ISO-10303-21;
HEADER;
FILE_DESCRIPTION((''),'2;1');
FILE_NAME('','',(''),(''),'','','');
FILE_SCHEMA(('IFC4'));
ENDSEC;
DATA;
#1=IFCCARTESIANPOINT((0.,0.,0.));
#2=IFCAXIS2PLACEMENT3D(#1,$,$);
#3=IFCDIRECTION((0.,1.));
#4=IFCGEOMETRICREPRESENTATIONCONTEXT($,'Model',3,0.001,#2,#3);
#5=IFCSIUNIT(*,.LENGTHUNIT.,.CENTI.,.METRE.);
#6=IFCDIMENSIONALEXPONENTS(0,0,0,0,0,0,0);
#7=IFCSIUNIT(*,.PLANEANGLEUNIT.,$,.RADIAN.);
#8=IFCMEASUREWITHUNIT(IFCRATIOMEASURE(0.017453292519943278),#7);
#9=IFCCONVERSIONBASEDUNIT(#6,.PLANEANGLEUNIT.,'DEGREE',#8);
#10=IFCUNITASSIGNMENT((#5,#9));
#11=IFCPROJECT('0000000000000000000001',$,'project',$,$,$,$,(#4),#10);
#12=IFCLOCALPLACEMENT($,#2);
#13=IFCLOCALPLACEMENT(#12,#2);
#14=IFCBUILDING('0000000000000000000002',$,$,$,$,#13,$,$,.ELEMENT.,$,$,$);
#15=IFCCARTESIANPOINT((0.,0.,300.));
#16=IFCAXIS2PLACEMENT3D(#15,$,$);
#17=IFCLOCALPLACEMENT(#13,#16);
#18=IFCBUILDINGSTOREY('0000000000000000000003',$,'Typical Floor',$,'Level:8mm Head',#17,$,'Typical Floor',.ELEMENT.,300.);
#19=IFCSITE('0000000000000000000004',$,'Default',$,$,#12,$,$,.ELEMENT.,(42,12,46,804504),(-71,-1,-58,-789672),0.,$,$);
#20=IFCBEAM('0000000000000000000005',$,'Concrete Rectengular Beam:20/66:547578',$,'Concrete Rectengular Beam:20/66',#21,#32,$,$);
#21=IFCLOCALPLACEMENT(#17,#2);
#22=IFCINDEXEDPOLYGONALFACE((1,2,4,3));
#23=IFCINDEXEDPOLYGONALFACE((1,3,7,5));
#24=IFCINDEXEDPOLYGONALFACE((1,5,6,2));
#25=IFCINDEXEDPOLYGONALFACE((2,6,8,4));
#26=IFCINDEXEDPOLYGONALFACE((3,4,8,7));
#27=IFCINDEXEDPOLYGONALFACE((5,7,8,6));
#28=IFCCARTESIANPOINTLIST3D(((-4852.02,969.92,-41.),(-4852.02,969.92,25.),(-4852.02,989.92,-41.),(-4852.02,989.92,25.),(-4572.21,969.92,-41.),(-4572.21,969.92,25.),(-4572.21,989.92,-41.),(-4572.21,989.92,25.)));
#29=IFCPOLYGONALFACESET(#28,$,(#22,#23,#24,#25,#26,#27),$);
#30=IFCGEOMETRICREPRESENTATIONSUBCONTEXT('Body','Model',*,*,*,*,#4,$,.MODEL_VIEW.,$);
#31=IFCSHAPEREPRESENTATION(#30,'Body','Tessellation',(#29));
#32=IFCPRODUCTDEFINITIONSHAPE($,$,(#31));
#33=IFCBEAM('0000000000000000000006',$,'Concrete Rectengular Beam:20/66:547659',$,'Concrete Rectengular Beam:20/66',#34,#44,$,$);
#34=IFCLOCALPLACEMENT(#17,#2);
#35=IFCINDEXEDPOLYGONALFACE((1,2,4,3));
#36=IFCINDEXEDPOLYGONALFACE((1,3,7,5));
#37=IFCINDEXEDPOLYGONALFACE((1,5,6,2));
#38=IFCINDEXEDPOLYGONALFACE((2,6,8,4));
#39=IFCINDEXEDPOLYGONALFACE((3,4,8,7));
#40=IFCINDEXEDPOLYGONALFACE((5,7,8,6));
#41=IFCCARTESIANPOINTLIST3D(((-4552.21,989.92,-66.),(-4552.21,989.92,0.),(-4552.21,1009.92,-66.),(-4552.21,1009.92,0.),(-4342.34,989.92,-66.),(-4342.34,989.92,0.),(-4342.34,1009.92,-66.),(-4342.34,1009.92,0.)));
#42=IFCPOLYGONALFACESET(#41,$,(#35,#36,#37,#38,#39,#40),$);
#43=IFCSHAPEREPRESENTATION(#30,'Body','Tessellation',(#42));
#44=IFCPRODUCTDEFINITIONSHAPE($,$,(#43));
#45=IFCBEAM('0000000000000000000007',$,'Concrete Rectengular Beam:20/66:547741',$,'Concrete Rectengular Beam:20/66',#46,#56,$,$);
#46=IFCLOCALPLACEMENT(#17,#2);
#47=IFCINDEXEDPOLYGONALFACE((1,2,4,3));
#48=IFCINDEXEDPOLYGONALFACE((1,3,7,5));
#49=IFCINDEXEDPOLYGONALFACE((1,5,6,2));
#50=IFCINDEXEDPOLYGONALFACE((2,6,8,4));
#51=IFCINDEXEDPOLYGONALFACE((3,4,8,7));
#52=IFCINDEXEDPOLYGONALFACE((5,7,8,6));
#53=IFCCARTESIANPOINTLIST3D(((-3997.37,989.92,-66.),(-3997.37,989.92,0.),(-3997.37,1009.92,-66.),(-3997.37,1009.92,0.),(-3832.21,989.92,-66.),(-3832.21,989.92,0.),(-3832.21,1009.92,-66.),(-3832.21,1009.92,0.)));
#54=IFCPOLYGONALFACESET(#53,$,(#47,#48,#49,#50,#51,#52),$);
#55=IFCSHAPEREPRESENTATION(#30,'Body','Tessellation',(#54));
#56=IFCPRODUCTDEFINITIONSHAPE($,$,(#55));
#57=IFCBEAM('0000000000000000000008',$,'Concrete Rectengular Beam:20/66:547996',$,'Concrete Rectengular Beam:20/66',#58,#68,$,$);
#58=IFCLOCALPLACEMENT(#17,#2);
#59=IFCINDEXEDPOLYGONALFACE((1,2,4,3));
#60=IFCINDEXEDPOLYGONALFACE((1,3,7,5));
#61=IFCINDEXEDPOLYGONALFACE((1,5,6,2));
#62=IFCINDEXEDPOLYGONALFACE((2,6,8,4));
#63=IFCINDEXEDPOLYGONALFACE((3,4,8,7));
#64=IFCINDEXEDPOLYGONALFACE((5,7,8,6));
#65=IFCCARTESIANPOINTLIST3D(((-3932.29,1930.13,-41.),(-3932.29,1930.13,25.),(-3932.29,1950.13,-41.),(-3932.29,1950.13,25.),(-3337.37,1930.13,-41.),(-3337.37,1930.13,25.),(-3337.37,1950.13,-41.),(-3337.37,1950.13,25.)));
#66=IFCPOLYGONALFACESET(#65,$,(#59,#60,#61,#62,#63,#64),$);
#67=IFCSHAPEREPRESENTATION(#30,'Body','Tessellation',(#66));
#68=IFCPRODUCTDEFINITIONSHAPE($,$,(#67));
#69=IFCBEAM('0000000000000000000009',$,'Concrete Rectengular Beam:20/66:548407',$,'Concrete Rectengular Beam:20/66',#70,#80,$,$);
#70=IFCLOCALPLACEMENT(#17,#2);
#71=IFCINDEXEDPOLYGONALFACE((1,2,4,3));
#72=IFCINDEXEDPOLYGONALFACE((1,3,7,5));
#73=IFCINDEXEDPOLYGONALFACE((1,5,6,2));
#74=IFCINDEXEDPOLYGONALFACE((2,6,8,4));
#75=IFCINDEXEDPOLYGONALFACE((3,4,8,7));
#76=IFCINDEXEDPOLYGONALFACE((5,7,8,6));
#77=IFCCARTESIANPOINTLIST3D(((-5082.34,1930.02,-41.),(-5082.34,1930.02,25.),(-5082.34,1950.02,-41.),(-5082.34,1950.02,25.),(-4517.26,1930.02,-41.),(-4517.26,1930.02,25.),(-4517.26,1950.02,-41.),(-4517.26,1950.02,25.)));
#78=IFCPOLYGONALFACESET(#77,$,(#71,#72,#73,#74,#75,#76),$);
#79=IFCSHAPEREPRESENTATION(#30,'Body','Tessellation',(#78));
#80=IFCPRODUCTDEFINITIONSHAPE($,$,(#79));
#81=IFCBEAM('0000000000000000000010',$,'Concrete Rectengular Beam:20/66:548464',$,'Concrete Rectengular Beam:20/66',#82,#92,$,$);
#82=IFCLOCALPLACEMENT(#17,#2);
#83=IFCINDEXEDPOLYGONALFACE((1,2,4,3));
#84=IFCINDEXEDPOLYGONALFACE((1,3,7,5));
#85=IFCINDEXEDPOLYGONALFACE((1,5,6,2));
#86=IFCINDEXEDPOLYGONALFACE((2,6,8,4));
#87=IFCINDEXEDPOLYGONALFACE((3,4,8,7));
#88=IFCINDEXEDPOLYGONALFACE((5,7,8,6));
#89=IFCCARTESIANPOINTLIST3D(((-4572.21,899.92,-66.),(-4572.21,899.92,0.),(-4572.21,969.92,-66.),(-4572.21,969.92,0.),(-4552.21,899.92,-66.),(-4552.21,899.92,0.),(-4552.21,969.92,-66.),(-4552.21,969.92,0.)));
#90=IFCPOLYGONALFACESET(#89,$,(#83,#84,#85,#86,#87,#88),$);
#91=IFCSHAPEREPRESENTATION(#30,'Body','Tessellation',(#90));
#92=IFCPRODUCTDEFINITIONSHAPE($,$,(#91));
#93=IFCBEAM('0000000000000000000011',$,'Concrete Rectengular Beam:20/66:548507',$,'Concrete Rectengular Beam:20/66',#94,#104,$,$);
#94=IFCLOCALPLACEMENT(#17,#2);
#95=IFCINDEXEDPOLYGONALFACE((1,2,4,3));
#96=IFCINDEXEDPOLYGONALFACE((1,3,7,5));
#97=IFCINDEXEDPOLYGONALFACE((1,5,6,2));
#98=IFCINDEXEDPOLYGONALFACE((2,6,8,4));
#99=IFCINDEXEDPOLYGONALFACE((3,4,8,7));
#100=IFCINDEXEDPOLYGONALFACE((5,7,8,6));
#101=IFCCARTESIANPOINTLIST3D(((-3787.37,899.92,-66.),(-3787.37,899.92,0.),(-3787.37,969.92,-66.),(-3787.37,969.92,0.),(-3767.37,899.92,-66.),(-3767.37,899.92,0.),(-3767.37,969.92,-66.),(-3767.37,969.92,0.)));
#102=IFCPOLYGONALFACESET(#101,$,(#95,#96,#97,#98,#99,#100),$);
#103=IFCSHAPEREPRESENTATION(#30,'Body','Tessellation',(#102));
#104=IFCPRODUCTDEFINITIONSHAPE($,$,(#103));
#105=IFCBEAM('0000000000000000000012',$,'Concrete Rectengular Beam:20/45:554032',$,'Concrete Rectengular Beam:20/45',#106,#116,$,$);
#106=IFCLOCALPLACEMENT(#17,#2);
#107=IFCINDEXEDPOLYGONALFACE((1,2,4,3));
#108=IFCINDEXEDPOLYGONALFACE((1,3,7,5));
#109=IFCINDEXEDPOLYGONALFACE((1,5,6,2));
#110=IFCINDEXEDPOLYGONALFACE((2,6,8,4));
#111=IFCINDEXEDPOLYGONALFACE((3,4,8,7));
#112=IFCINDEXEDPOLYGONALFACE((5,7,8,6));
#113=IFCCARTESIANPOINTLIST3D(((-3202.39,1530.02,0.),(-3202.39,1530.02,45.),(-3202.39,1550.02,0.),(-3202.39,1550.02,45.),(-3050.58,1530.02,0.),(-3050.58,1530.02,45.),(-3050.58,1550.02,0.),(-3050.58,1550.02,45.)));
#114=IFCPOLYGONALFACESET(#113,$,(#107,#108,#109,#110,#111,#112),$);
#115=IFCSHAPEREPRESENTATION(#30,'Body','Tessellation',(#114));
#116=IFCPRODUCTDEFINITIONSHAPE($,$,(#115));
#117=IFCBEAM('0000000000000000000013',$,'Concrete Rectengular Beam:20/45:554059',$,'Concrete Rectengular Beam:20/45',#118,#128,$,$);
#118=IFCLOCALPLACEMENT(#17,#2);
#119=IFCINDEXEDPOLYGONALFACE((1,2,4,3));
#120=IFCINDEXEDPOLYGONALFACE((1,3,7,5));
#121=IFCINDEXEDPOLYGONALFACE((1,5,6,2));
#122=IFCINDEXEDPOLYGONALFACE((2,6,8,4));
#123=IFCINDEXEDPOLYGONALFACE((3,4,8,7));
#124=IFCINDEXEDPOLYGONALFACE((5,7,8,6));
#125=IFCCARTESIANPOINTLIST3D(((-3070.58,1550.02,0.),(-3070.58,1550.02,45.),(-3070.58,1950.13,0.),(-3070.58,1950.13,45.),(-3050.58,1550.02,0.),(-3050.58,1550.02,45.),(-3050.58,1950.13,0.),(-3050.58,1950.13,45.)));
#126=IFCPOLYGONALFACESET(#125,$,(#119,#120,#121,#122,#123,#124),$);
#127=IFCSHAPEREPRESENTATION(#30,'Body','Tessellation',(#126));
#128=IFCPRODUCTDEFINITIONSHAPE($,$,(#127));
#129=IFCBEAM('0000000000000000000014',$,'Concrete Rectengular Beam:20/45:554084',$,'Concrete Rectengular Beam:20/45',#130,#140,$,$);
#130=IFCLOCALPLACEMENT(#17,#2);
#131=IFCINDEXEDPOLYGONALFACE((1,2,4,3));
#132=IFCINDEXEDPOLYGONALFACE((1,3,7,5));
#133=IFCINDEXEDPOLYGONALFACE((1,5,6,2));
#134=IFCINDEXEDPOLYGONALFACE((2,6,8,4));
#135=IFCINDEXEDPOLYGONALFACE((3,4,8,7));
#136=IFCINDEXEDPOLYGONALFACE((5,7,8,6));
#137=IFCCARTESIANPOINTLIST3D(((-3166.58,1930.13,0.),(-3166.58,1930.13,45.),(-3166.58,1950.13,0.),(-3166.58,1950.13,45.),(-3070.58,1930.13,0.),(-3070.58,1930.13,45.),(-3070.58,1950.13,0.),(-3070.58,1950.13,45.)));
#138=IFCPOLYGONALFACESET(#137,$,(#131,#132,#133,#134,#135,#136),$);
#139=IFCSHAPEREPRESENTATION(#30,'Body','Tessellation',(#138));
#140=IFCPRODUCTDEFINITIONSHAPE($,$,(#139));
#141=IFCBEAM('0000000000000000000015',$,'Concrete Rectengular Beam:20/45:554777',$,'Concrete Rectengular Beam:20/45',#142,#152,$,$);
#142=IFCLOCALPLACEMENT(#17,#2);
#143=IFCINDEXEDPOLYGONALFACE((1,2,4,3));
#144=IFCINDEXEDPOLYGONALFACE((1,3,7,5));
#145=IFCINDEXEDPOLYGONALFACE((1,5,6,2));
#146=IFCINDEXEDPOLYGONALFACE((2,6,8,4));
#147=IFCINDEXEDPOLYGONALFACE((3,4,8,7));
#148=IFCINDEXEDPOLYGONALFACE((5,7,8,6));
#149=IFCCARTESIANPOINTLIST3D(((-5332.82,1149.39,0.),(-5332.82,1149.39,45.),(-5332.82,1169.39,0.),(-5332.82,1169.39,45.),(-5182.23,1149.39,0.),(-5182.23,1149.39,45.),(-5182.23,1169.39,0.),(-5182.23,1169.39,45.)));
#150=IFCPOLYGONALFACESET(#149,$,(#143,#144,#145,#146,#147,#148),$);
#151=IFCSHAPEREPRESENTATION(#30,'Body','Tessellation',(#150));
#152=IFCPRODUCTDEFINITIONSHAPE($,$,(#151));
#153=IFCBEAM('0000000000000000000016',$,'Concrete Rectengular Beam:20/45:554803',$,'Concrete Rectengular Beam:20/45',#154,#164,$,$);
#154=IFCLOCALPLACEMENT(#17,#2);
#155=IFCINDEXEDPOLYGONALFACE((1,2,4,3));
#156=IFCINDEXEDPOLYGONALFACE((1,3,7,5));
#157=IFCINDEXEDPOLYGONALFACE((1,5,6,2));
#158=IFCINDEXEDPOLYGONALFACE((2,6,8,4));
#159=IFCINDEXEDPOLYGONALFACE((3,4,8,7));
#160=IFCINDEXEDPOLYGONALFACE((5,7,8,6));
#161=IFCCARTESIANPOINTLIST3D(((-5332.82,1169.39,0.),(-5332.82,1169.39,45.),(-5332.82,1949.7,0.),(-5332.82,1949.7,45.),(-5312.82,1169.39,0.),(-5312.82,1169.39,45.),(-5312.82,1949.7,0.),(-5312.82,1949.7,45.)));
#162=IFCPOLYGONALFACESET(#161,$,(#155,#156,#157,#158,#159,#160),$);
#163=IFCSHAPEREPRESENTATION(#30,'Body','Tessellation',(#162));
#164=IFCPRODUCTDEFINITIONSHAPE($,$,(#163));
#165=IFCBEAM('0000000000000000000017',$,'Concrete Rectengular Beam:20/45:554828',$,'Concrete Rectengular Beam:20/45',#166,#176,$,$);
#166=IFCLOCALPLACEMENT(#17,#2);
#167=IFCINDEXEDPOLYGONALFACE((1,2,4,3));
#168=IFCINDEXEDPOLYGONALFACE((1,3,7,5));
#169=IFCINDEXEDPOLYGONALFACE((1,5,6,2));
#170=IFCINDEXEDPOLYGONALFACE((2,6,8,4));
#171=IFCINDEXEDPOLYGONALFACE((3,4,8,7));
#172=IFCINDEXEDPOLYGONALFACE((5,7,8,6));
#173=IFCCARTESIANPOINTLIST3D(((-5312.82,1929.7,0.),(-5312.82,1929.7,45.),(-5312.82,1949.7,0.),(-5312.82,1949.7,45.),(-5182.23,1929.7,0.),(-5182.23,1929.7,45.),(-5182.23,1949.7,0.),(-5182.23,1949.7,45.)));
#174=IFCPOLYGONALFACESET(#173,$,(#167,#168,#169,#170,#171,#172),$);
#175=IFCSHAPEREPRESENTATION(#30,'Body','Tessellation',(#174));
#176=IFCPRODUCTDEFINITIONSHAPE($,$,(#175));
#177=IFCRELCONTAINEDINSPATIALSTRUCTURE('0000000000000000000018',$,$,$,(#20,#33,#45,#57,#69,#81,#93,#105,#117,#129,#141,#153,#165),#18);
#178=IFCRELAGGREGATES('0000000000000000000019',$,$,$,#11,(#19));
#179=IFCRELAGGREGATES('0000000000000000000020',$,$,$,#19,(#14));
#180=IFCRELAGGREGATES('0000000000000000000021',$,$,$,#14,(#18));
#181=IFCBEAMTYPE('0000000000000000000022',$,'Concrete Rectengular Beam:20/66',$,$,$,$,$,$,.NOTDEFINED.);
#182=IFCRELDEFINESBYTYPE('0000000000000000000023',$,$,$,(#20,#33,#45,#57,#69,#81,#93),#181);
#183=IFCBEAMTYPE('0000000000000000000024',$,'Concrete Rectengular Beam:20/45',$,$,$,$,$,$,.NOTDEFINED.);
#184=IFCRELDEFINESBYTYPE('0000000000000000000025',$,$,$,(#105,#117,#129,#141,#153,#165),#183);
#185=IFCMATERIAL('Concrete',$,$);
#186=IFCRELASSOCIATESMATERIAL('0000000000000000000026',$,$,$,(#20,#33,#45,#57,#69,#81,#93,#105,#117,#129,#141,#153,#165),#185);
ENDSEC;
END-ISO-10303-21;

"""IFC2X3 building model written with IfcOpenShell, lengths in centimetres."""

from ifc_helpers import new_model, entity, si_unit, converted_unit, direction, frame, frame_2d, origin, place, context, subcontext, project, spatial, rectangle, extrude, material, type_object, element, save


model = new_model("IFC2X3")

# Units and contexts
model_context = context("Model", 3, precision=0.001, world=origin(), true_north=direction((0.0, 1.0)))
body_context = subcontext(model_context, "Body", "Model", "MODEL_VIEW")
ifc_project = project(units=[si_unit("LENGTHUNIT", "METRE", prefix="CENTI"), converted_unit("PLANEANGLEUNIT", "DEGREE", entity("IfcRatioMeasure", 0.017453292519943278), si_unit("PLANEANGLEUNIT", "RADIAN"), dimensions=[0, 0, 0, 0, 0, 0, 0])], contexts=[model_context])

# Site, building, storey
site_placement = place(None, origin())
site = spatial("IfcSite", under=ifc_project, at=site_placement, Name="Default", CompositionType="ELEMENT", RefLatitude=(42, 12, 46, 804504), RefLongitude=(-71, -1, -58, -789672), RefElevation=0.0)
building_placement = place(site_placement, origin())
building = spatial("IfcBuilding", under=site, at=building_placement, CompositionType="ELEMENT")
storey_placement = place(building_placement, frame((0.0, 0.0, 300.0)))
storey = spatial("IfcBuildingStorey", under=building, at=storey_placement, Name="Typical Floor", ObjectType="Level:8mm Head", LongName="Typical Floor", CompositionType="ELEMENT", Elevation=300.0)

# Beams
ifc_material = material(Name="Concrete")
beam_type_1 = type_object("IfcBeamType", Name="Concrete Rectengular Beam:20/66", PredefinedType="NOTDEFINED")
beam_1_placement = place(storey_placement, frame((-4852.02, 979.92, 0.0)))
element("IfcBeam", 1, at=beam_1_placement, inside=storey, type_object=beam_type_1, material=ifc_material, Name="Concrete Rectengular Beam:20/66:547578", ObjectType="Concrete Rectengular Beam:20/66", context=body_context, shape_type="SweptSolid", body=[
    extrude(rectangle(XDim=66.0, YDim=20.0, at=frame_2d((0.0, 0.0), x_axis=(1.0, 0.0))), frame((0.0, 0.0, -8.0), z_axis=(1.0, 0.0, 0.0), x_axis=(0.0, 0.0, -1.0)), (0.0, 0.0, 1.0), 279.82),
])
beam_2_placement = place(storey_placement, frame((-4562.21, 999.92, 0.0)))
element("IfcBeam", 2, at=beam_2_placement, inside=storey, type_object=beam_type_1, material=ifc_material, Name="Concrete Rectengular Beam:20/66:547659", ObjectType="Concrete Rectengular Beam:20/66", context=body_context, shape_type="SweptSolid", body=[
    extrude(rectangle(XDim=66.0, YDim=20.0, at=frame_2d((0.0, 0.0), x_axis=(1.0, 0.0))), frame((10.0, 0.0, -33.0), z_axis=(1.0, 0.0, 0.0), x_axis=(0.0, 0.0, -1.0)), (0.0, 0.0, 1.0), 209.87),
])
beam_3_placement = place(storey_placement, frame((-3822.21, 999.92, 0.0), z_axis=(0.0, 0.0, 1.0), x_axis=(-1.0, 0.0, 0.0)))
element("IfcBeam", 3, at=beam_3_placement, inside=storey, type_object=beam_type_1, material=ifc_material, Name="Concrete Rectengular Beam:20/66:547741", ObjectType="Concrete Rectengular Beam:20/66", context=body_context, shape_type="SweptSolid", body=[
    extrude(rectangle(XDim=66.0, YDim=20.0, at=frame_2d((0.0, 0.0), x_axis=(1.0, 0.0))), frame((10.0, 0.0, -33.0), z_axis=(1.0, 0.0, 0.0), x_axis=(0.0, 0.0, -1.0)), (0.0, 0.0, 1.0), 165.16),
])
beam_4_placement = place(storey_placement, frame((-3337.37, 1940.13, 0.0), z_axis=(0.0, 0.0, 1.0), x_axis=(-1.0, 0.0, 0.0)))
element("IfcBeam", 4, at=beam_4_placement, inside=storey, type_object=beam_type_1, material=ifc_material, Name="Concrete Rectengular Beam:20/66:547996", ObjectType="Concrete Rectengular Beam:20/66", context=body_context, shape_type="SweptSolid", body=[
    extrude(rectangle(XDim=66.0, YDim=20.0, at=frame_2d((0.0, 0.0), x_axis=(1.0, 0.0))), frame((0.0, 0.0, -8.0), z_axis=(1.0, 0.0, 0.0), x_axis=(0.0, 0.0, -1.0)), (0.0, 0.0, 1.0), 594.92),
])
beam_5_placement = place(storey_placement, frame((-4517.26, 1940.02, 0.0), z_axis=(0.0, 0.0, 1.0), x_axis=(-1.0, 0.0, 0.0)))
element("IfcBeam", 5, at=beam_5_placement, inside=storey, type_object=beam_type_1, material=ifc_material, Name="Concrete Rectengular Beam:20/66:548407", ObjectType="Concrete Rectengular Beam:20/66", context=body_context, shape_type="SweptSolid", body=[
    extrude(rectangle(XDim=66.0, YDim=20.0, at=frame_2d((0.0, 0.0), x_axis=(1.0, 0.0))), frame((0.0, 0.0, -8.0), z_axis=(1.0, 0.0, 0.0), x_axis=(0.0, 0.0, -1.0)), (0.0, 0.0, 1.0), 565.08),
])
beam_6_placement = place(storey_placement, frame((-4562.21, 989.92, 0.0), z_axis=(0.0, 0.0, 1.0), x_axis=(0.0, -1.0, 0.0)))
element("IfcBeam", 6, at=beam_6_placement, inside=storey, type_object=beam_type_1, material=ifc_material, Name="Concrete Rectengular Beam:20/66:548464", ObjectType="Concrete Rectengular Beam:20/66", context=body_context, shape_type="SweptSolid", body=[
    extrude(rectangle(XDim=66.0, YDim=20.0, at=frame_2d((0.0, 0.0), x_axis=(1.0, 0.0))), frame((20.0, 0.0, -33.0), z_axis=(1.0, 0.0, 0.0), x_axis=(0.0, 0.0, -1.0)), (0.0, 0.0, 1.0), 70.0),
])
beam_7_placement = place(storey_placement, frame((-3777.37, 969.92, 0.0), z_axis=(0.0, 0.0, 1.0), x_axis=(0.0, -1.0, 0.0)))
element("IfcBeam", 7, at=beam_7_placement, inside=storey, type_object=beam_type_1, material=ifc_material, Name="Concrete Rectengular Beam:20/66:548507", ObjectType="Concrete Rectengular Beam:20/66", context=body_context, shape_type="SweptSolid", body=[
    extrude(rectangle(XDim=66.0, YDim=20.0, at=frame_2d((0.0, 0.0), x_axis=(1.0, 0.0))), frame((0.0, 0.0, -33.0), z_axis=(1.0, 0.0, 0.0), x_axis=(0.0, 0.0, -1.0)), (0.0, 0.0, 1.0), 70.0),
])
beam_type_2 = type_object("IfcBeamType", Name="Concrete Rectengular Beam:20/45", PredefinedType="NOTDEFINED")
beam_8_placement = place(storey_placement, frame((-3202.39, 1540.02, 0.0)))
element("IfcBeam", 8, at=beam_8_placement, inside=storey, type_object=beam_type_2, material=ifc_material, Name="Concrete Rectengular Beam:20/45:554032", ObjectType="Concrete Rectengular Beam:20/45", context=body_context, shape_type="SweptSolid", body=[
    extrude(rectangle(XDim=45.0, YDim=20.0, at=frame_2d((0.0, 0.0), x_axis=(1.0, 0.0))), frame((0.0, 0.0, 22.5), z_axis=(1.0, 0.0, 0.0), x_axis=(0.0, 0.0, -1.0)), (0.0, 0.0, 1.0), 151.81),
])
beam_9_placement = place(storey_placement, frame((-3060.58, 1540.02, 0.0), z_axis=(0.0, 0.0, 1.0), x_axis=(0.0, 1.0, 0.0)))
element("IfcBeam", 9, at=beam_9_placement, inside=storey, type_object=beam_type_2, material=ifc_material, Name="Concrete Rectengular Beam:20/45:554059", ObjectType="Concrete Rectengular Beam:20/45", context=body_context, shape_type="SweptSolid", body=[
    extrude(rectangle(XDim=45.0, YDim=20.0, at=frame_2d((0.0, 0.0), x_axis=(1.0, 0.0))), frame((10.0, 0.0, 22.5), z_axis=(1.0, 0.0, 0.0), x_axis=(0.0, 0.0, -1.0)), (0.0, 0.0, 1.0), 400.11),
])
beam_10_placement = place(storey_placement, frame((-3060.58, 1940.13, 0.0), z_axis=(0.0, 0.0, 1.0), x_axis=(-1.0, 0.0, 0.0)))
element("IfcBeam", 10, at=beam_10_placement, inside=storey, type_object=beam_type_2, material=ifc_material, Name="Concrete Rectengular Beam:20/45:554084", ObjectType="Concrete Rectengular Beam:20/45", context=body_context, shape_type="SweptSolid", body=[
    extrude(rectangle(XDim=45.0, YDim=20.0, at=frame_2d((0.0, 0.0), x_axis=(1.0, 0.0))), frame((10.0, 0.0, 22.5), z_axis=(1.0, 0.0, 0.0), x_axis=(0.0, 0.0, -1.0)), (0.0, 0.0, 1.0), 96.0),
])
beam_11_placement = place(storey_placement, frame((-5182.23, 1159.39, 0.0), z_axis=(0.0, 0.0, 1.0), x_axis=(-1.0, 0.0, 0.0)))
element("IfcBeam", 11, at=beam_11_placement, inside=storey, type_object=beam_type_2, material=ifc_material, Name="Concrete Rectengular Beam:20/45:554777", ObjectType="Concrete Rectengular Beam:20/45", context=body_context, shape_type="SweptSolid", body=[
    extrude(rectangle(XDim=45.0, YDim=20.0, at=frame_2d((0.0, 0.0), x_axis=(1.0, 0.0))), frame((0.0, 0.0, 22.5), z_axis=(1.0, 0.0, 0.0), x_axis=(0.0, 0.0, -1.0)), (0.0, 0.0, 1.0), 150.59),
])
beam_12_placement = place(storey_placement, frame((-5322.82, 1159.39, 0.0), z_axis=(0.0, 0.0, 1.0), x_axis=(0.0, 1.0, 0.0)))
element("IfcBeam", 12, at=beam_12_placement, inside=storey, type_object=beam_type_2, material=ifc_material, Name="Concrete Rectengular Beam:20/45:554803", ObjectType="Concrete Rectengular Beam:20/45", context=body_context, shape_type="SweptSolid", body=[
    extrude(rectangle(XDim=45.0, YDim=20.0, at=frame_2d((0.0, 0.0), x_axis=(1.0, 0.0))), frame((10.0, 0.0, 22.5), z_axis=(1.0, 0.0, 0.0), x_axis=(0.0, 0.0, -1.0)), (0.0, 0.0, 1.0), 780.31),
])
beam_13_placement = place(storey_placement, frame((-5322.82, 1939.7, 0.0)))
element("IfcBeam", 13, at=beam_13_placement, inside=storey, type_object=beam_type_2, material=ifc_material, Name="Concrete Rectengular Beam:20/45:554828", ObjectType="Concrete Rectengular Beam:20/45", context=body_context, shape_type="SweptSolid", body=[
    extrude(rectangle(XDim=45.0, YDim=20.0, at=frame_2d((0.0, 0.0), x_axis=(1.0, 0.0))), frame((10.0, 0.0, 22.5), z_axis=(1.0, 0.0, 0.0), x_axis=(0.0, 0.0, -1.0)), (0.0, 0.0, 1.0), 130.59),
])

save(model, "model.ifc")
